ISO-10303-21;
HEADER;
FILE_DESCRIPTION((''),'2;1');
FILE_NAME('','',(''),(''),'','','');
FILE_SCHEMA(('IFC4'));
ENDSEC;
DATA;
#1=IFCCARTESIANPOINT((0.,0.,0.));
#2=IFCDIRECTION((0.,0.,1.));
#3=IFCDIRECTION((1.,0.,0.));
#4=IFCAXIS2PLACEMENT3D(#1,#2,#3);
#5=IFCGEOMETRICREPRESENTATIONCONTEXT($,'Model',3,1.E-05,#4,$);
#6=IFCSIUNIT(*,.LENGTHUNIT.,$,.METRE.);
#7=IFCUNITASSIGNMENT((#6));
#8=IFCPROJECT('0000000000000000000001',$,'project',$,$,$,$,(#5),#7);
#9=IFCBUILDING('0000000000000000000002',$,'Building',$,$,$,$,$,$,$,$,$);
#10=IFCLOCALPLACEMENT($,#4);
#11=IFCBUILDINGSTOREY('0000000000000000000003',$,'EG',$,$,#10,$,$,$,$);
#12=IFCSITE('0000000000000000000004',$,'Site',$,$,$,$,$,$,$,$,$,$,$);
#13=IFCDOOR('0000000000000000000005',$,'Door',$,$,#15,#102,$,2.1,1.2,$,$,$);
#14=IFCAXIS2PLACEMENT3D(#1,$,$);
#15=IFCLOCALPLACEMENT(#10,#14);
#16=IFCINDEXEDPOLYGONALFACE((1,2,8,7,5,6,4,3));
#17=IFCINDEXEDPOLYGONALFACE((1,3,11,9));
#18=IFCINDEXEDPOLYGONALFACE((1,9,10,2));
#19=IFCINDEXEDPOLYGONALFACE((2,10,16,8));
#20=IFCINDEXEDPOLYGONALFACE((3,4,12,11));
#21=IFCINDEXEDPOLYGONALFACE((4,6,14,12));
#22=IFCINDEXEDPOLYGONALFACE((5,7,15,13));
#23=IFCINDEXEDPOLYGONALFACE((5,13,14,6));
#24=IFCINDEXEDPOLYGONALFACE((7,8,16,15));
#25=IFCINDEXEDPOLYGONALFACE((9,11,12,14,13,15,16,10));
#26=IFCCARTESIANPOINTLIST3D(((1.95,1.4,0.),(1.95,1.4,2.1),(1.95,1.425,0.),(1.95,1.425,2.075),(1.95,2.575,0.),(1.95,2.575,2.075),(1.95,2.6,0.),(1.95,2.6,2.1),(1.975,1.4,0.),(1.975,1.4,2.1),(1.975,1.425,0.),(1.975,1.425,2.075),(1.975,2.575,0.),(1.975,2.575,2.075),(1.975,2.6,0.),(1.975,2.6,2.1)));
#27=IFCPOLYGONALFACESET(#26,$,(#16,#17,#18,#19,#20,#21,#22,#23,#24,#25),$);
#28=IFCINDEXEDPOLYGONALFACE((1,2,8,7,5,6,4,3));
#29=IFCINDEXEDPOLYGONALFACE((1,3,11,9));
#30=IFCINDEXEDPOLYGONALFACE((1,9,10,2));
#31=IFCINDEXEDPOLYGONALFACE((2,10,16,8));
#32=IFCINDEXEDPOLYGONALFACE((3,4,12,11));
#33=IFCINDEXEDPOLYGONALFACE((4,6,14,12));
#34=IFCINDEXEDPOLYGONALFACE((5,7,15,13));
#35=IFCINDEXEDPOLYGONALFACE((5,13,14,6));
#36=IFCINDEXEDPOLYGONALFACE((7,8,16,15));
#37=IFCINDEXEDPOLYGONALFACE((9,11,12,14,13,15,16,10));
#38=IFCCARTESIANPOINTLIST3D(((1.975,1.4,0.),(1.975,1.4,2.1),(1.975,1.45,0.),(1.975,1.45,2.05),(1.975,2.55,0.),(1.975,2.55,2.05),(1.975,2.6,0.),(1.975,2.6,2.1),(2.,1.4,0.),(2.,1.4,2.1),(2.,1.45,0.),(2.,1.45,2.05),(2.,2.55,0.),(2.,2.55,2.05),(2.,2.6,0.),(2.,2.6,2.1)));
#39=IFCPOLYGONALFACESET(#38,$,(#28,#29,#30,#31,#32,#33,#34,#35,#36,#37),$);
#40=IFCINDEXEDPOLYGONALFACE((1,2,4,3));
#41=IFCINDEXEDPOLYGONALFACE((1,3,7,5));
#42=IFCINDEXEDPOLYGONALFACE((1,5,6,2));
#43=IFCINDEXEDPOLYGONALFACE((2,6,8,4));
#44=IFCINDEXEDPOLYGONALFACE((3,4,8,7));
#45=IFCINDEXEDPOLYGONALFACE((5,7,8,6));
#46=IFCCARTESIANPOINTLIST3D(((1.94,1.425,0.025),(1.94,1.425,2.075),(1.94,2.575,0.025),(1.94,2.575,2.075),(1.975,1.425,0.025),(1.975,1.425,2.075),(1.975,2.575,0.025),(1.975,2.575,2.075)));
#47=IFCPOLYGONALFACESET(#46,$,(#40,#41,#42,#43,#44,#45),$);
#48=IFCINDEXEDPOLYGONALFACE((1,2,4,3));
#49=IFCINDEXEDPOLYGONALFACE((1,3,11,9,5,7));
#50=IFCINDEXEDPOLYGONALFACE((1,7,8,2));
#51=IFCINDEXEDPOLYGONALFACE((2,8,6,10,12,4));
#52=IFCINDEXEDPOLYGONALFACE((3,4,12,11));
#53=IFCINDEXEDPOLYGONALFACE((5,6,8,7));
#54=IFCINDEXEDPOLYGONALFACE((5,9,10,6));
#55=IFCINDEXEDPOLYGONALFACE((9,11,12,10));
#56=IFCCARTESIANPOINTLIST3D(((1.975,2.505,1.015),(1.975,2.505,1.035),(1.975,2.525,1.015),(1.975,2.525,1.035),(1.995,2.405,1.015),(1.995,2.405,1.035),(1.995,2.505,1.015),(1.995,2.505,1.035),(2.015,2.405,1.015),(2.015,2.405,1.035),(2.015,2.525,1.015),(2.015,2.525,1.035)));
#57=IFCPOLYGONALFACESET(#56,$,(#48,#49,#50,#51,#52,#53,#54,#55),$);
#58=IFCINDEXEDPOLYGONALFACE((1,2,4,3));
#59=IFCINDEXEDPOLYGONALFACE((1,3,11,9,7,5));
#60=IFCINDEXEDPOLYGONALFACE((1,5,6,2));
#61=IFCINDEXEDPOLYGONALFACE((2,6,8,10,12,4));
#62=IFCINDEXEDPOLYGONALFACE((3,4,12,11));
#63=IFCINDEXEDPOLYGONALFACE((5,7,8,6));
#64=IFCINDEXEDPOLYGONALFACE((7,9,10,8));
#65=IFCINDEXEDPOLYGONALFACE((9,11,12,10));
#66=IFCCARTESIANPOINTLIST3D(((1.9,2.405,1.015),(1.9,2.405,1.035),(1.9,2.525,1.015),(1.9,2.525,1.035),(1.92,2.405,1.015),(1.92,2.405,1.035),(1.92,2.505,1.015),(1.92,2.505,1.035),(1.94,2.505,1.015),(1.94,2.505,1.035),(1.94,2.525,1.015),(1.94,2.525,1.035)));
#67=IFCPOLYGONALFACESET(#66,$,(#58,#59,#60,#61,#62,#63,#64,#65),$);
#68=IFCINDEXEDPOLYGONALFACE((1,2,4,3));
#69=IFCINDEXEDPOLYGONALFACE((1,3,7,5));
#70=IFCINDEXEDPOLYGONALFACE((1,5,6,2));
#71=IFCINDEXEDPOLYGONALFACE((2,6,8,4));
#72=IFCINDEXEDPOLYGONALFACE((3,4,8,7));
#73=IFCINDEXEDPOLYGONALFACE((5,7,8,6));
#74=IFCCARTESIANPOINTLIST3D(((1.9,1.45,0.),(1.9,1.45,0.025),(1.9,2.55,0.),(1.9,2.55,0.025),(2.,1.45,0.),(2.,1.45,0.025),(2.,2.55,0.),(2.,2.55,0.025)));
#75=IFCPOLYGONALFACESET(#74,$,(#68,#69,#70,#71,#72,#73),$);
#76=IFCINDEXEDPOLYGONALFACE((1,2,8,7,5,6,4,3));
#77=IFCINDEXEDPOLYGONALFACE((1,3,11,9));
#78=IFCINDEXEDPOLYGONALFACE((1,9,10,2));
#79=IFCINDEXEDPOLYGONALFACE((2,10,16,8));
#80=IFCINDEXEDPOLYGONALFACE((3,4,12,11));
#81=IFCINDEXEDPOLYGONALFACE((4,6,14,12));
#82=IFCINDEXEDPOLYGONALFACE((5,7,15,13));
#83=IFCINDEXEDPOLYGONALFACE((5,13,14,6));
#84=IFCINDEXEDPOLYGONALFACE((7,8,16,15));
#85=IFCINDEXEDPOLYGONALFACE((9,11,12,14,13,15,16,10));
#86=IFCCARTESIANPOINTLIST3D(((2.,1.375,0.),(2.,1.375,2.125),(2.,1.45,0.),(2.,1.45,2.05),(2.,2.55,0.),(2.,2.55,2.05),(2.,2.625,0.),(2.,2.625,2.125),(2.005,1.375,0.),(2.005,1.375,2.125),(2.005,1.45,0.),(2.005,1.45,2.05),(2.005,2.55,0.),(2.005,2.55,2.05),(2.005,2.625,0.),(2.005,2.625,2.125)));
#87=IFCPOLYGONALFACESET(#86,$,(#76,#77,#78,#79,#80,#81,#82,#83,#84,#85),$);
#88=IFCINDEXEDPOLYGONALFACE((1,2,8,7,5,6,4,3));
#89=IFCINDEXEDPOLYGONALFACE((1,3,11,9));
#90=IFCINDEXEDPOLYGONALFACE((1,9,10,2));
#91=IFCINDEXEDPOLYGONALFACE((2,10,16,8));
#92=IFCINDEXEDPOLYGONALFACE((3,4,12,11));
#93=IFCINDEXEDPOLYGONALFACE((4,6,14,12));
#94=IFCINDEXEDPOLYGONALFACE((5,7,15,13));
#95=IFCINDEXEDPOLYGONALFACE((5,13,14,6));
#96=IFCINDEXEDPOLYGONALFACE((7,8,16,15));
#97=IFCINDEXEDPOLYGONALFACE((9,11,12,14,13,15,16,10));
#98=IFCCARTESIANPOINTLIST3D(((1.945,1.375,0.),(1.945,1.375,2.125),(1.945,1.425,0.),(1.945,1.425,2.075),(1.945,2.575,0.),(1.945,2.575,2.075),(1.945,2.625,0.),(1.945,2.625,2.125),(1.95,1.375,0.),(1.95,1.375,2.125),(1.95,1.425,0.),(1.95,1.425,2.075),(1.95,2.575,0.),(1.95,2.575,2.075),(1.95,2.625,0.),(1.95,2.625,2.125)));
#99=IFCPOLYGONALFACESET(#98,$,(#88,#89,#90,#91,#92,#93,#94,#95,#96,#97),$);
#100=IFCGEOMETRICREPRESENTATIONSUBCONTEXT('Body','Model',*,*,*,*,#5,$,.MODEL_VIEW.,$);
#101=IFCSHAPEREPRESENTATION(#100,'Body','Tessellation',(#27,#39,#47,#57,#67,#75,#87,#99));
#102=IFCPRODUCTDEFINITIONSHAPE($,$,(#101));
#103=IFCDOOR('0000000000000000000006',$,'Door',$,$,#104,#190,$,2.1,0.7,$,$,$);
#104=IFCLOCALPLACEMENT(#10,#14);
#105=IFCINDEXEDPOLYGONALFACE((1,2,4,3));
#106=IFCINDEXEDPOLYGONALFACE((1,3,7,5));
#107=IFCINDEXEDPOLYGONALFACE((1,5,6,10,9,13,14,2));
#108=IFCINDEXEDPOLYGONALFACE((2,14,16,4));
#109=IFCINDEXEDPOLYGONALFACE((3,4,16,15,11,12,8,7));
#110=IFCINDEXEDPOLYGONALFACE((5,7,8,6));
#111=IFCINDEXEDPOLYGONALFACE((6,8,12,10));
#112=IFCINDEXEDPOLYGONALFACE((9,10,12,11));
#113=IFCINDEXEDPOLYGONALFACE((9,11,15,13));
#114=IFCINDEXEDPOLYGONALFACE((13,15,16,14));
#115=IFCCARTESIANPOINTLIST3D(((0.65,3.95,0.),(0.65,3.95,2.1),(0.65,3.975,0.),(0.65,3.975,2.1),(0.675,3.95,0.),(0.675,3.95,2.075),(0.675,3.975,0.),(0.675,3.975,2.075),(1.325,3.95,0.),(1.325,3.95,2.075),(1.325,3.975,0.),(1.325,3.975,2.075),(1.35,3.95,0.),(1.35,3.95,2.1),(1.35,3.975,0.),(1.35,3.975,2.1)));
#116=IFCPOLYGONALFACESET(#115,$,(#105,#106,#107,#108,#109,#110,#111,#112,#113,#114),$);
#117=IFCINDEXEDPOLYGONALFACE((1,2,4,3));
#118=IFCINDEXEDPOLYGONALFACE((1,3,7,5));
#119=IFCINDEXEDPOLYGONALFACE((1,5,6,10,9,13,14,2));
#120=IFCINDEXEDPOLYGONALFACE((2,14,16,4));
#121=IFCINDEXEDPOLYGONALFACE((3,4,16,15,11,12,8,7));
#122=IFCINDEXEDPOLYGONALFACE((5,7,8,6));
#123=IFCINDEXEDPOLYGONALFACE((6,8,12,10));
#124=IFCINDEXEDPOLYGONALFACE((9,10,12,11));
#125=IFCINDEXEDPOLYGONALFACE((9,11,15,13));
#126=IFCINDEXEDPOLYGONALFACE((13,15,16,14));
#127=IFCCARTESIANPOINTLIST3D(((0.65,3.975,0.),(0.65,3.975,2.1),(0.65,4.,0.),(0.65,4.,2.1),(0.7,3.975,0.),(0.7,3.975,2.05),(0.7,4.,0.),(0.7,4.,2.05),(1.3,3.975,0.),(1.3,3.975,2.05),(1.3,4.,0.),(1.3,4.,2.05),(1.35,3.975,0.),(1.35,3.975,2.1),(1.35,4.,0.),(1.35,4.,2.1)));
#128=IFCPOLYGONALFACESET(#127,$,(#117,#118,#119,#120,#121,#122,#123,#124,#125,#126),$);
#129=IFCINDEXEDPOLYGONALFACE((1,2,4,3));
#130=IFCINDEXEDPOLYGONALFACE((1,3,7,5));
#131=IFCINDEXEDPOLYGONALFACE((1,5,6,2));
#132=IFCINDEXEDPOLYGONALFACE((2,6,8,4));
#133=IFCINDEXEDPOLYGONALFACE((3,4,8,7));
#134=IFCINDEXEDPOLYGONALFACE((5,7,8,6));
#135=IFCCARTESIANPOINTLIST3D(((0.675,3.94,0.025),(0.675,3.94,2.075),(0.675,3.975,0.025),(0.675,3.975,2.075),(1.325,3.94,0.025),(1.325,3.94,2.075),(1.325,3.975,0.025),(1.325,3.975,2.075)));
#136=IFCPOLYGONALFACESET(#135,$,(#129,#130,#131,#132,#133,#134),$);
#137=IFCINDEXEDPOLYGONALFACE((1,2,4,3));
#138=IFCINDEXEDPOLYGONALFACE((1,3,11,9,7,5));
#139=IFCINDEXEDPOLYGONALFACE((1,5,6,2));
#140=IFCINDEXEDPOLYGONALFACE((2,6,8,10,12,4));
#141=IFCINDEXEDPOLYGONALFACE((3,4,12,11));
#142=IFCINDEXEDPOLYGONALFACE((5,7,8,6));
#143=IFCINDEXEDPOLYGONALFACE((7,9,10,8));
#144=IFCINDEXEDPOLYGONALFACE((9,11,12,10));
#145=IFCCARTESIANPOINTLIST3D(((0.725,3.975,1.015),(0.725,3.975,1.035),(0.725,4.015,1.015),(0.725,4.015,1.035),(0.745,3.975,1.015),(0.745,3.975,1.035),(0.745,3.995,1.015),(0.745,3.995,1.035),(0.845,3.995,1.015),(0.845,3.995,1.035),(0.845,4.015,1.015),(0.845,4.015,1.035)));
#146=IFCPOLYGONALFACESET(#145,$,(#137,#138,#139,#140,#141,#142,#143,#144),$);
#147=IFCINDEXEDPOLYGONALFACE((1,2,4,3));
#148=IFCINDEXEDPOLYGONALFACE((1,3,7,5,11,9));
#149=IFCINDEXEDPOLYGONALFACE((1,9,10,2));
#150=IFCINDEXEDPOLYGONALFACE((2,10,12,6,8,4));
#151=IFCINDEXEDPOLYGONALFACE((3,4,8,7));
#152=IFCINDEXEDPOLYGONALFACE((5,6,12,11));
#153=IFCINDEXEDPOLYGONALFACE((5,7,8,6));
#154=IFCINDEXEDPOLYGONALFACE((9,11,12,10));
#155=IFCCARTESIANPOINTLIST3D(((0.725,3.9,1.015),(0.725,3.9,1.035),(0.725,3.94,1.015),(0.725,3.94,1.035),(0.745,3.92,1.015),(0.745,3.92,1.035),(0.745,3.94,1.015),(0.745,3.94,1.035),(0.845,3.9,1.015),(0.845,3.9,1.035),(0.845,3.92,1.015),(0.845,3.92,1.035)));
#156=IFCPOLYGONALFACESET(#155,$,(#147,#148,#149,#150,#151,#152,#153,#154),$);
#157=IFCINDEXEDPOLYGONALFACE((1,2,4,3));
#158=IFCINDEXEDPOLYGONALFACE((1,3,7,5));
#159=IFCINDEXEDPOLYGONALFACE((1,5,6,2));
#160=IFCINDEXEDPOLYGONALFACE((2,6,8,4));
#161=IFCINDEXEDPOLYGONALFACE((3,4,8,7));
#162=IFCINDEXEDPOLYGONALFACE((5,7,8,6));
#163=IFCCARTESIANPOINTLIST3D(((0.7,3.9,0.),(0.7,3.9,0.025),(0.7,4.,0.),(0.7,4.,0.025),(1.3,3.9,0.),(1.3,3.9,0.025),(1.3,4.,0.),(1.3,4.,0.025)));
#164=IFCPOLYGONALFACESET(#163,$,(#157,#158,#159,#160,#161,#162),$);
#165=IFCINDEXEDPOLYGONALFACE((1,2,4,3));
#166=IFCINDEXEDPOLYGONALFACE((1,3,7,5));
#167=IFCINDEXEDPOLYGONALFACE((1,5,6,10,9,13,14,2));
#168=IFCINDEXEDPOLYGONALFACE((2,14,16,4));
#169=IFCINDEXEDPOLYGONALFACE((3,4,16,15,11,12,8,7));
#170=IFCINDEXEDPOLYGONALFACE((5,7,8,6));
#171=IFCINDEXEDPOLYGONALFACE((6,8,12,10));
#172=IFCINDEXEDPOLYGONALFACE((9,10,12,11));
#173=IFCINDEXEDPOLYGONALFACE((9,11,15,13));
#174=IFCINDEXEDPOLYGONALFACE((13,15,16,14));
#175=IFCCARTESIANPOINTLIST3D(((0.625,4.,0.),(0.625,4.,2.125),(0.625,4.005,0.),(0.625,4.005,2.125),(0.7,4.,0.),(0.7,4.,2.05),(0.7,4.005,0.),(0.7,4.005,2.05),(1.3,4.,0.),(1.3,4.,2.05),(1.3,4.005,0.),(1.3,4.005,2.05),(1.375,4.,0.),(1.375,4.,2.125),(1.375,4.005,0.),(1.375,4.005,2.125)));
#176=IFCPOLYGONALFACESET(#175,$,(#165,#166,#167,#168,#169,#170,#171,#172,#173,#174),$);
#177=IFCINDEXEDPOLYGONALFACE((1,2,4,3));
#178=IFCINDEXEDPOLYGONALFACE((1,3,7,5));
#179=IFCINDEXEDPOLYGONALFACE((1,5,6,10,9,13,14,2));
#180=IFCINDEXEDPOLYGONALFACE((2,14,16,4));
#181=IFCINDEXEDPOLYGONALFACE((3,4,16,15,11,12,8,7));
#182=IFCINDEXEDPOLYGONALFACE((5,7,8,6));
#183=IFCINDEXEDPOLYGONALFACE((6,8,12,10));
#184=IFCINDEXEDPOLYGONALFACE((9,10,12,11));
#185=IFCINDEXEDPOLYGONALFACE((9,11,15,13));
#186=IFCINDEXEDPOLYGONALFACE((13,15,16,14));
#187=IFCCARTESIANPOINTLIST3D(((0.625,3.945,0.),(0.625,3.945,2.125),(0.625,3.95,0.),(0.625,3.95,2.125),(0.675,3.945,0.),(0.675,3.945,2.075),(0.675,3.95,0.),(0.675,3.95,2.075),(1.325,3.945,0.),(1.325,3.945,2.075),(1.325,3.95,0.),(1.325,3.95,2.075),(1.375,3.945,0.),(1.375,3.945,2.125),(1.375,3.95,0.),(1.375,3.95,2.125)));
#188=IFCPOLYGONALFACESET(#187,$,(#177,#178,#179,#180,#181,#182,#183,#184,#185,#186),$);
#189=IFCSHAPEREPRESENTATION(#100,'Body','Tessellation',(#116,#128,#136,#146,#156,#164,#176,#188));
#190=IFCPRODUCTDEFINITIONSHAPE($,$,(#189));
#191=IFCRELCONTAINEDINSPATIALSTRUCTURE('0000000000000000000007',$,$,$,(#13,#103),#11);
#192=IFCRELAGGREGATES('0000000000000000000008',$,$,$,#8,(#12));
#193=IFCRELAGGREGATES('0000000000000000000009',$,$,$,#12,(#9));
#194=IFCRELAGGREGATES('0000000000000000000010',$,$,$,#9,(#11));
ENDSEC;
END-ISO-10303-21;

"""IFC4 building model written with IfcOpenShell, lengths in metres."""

from ifc_helpers import new_model, si_unit, frame, origin_with_axes, place, context, subcontext, project, spatial, line, indexed_curve, outline, extrude, element, save


model = new_model("IFC4")

# Units and contexts
model_context = context("Model", 3, precision=1e-05, world=origin_with_axes())
body_context = subcontext(model_context, "Body", "Model", "MODEL_VIEW")
ifc_project = project(units=[si_unit("LENGTHUNIT", "METRE")], contexts=[model_context])

# Site, building, storey
site = spatial("IfcSite", under=ifc_project, Name="Site")
building = spatial("IfcBuilding", under=site, Name="Building")
storey_placement = place(None, origin_with_axes())
storey = spatial("IfcBuildingStorey", under=building, at=storey_placement, Name="EG")

# Doors
door_1_placement = place(storey_placement, frame((2.0, 1.4, 0.0), z_axis=(0.0, 0.0, 1.0), x_axis=(0.0, 1.0, 0.0)))
element("IfcDoor", 1, at=door_1_placement, inside=storey, Name="Door", OverallHeight=2.1, OverallWidth=1.2, context=body_context, shape_type="SweptSolid", body=[
    extrude(outline(indexed_curve([(0.0, 0.0), (0.0, 2.1), (1.2, 2.1), (1.2, 0.0), (1.175, 0.0), (1.175, 2.075), (0.025, 2.075), (0.025, 0.0)], segments=[line(1, 2, 3, 4, 5, 6, 7, 8, 1)])), frame((0.0, 0.025, 0.0), z_axis=(0.0, -1.0, 0.0), x_axis=(1.0, 0.0, 0.0)), (0.0, 0.0, -1.0), 0.025),
    extrude(outline(indexed_curve([(0.0, 0.0), (0.0, 2.1), (1.2, 2.1), (1.2, 0.0), (1.15, 0.0), (1.15, 2.05), (0.05, 2.05), (0.05, 0.0)], segments=[line(1, 2, 3, 4, 5, 6, 7, 8, 1)])), frame((0.0, 0.0, 0.0), z_axis=(0.0, -1.0, 0.0), x_axis=(1.0, 0.0, 0.0)), (0.0, 0.0, -1.0), 0.025),
    extrude(outline(indexed_curve([(0.0, 0.0), (1.15, 0.0), (1.15, 0.035), (0.0, 0.035)], segments=[line(1, 2, 3, 4, 1)])), frame((0.025, 0.025, 0.025), z_axis=(0.0, 0.0, 1.0), x_axis=(1.0, 0.0, 0.0)), (0.0, 0.0, 1.0), 2.05),
    extrude(outline(indexed_curve([(0.0, 0.0), (0.0, -0.04), (-0.12, -0.04), (-0.12, -0.02), (-0.02, -0.02), (-0.02, 0.0)], segments=[line(1, 2, 3, 4, 5, 6, 1)])), frame((1.125, 0.025, 1.015), z_axis=(0.0, 0.0, 1.0), x_axis=(1.0, 0.0, 0.0)), (0.0, 0.0, 1.0), 0.02),
    extrude(outline(indexed_curve([(0.0, 0.0), (0.0, 0.04), (-0.12, 0.04), (-0.12, 0.02), (-0.02, 0.02), (-0.02, 0.0)], segments=[line(1, 2, 3, 4, 5, 6, 1)])), frame((1.125, 0.06, 1.015), z_axis=(0.0, 0.0, 1.0), x_axis=(1.0, 0.0, 0.0)), (0.0, 0.0, 1.0), 0.02),
    extrude(outline(indexed_curve([(0.0, 0.0), (1.1, 0.0), (1.1, 0.1), (0.0, 0.1)], segments=[line(1, 2, 3, 4, 1)])), frame((0.05, 0.0, 0.0), z_axis=(0.0, 0.0, 1.0), x_axis=(1.0, 0.0, 0.0)), (0.0, 0.0, 1.0), 0.025),
    extrude(outline(indexed_curve([(0.0, 0.0), (0.0, 2.125), (1.25, 2.125), (1.25, 0.0), (1.175, 0.0), (1.175, 2.05), (0.075, 2.05), (0.075, 0.0)], segments=[line(1, 2, 3, 4, 5, 6, 7, 8, 1)])), frame((-0.025, -0.005, 0.0), z_axis=(0.0, -1.0, 0.0), x_axis=(1.0, 0.0, 0.0)), (0.0, 0.0, -1.0), 0.005),
    extrude(outline(indexed_curve([(0.0, 0.0), (0.0, 2.125), (1.25, 2.125), (1.25, 0.0), (1.2, 0.0), (1.2, 2.075), (0.05, 2.075), (0.05, 0.0)], segments=[line(1, 2, 3, 4, 5, 6, 7, 8, 1)])), frame((-0.025, 0.05, 0.0), z_axis=(0.0, -1.0, 0.0), x_axis=(1.0, 0.0, 0.0)), (0.0, 0.0, -1.0), 0.005),
])
door_2_placement = place(storey_placement, frame((1.35, 4.0, 0.0), z_axis=(0.0, 0.0, 1.0), x_axis=(-1.0, 0.0, 0.0)))
element("IfcDoor", 2, at=door_2_placement, inside=storey, Name="Door", OverallHeight=2.1, OverallWidth=0.7, context=body_context, shape_type="SweptSolid", body=[
    extrude(outline(indexed_curve([(0.0, 0.0), (0.0, 2.1), (0.7, 2.1), (0.7, 0.0), (0.675, 0.0), (0.675, 2.075), (0.025, 2.075), (0.025, 0.0)], segments=[line(1, 2, 3, 4, 5, 6, 7, 8, 1)])), frame((0.0, 0.025, 0.0), z_axis=(0.0, -1.0, 0.0), x_axis=(1.0, 0.0, 0.0)), (0.0, 0.0, -1.0), 0.025),
    extrude(outline(indexed_curve([(0.0, 0.0), (0.0, 2.1), (0.7, 2.1), (0.7, 0.0), (0.65, 0.0), (0.65, 2.05), (0.05, 2.05), (0.05, 0.0)], segments=[line(1, 2, 3, 4, 5, 6, 7, 8, 1)])), frame((0.0, 0.0, 0.0), z_axis=(0.0, -1.0, 0.0), x_axis=(1.0, 0.0, 0.0)), (0.0, 0.0, -1.0), 0.025),
    extrude(outline(indexed_curve([(0.0, 0.0), (0.65, 0.0), (0.65, 0.035), (0.0, 0.035)], segments=[line(1, 2, 3, 4, 1)])), frame((0.025, 0.025, 0.025), z_axis=(0.0, 0.0, 1.0), x_axis=(1.0, 0.0, 0.0)), (0.0, 0.0, 1.0), 2.05),
    extrude(outline(indexed_curve([(0.0, 0.0), (0.0, -0.04), (-0.12, -0.04), (-0.12, -0.02), (-0.02, -0.02), (-0.02, 0.0)], segments=[line(1, 2, 3, 4, 5, 6, 1)])), frame((0.625, 0.025, 1.015), z_axis=(0.0, 0.0, 1.0), x_axis=(1.0, 0.0, 0.0)), (0.0, 0.0, 1.0), 0.02),
    extrude(outline(indexed_curve([(0.0, 0.0), (0.0, 0.04), (-0.12, 0.04), (-0.12, 0.02), (-0.02, 0.02), (-0.02, 0.0)], segments=[line(1, 2, 3, 4, 5, 6, 1)])), frame((0.625, 0.06, 1.015), z_axis=(0.0, 0.0, 1.0), x_axis=(1.0, 0.0, 0.0)), (0.0, 0.0, 1.0), 0.02),
    extrude(outline(indexed_curve([(0.0, 0.0), (0.6, 0.0), (0.6, 0.1), (0.0, 0.1)], segments=[line(1, 2, 3, 4, 1)])), frame((0.05, 0.0, 0.0), z_axis=(0.0, 0.0, 1.0), x_axis=(1.0, 0.0, 0.0)), (0.0, 0.0, 1.0), 0.025),
    extrude(outline(indexed_curve([(0.0, 0.0), (0.0, 2.125), (0.75, 2.125), (0.75, 0.0), (0.675, 0.0), (0.675, 2.05), (0.075, 2.05), (0.075, 0.0)], segments=[line(1, 2, 3, 4, 5, 6, 7, 8, 1)])), frame((-0.025, -0.005, 0.0), z_axis=(0.0, -1.0, 0.0), x_axis=(1.0, 0.0, 0.0)), (0.0, 0.0, -1.0), 0.005),
    extrude(outline(indexed_curve([(0.0, 0.0), (0.0, 2.125), (0.75, 2.125), (0.75, 0.0), (0.7, 0.0), (0.7, 2.075), (0.05, 2.075), (0.05, 0.0)], segments=[line(1, 2, 3, 4, 5, 6, 7, 8, 1)])), frame((-0.025, 0.05, 0.0), z_axis=(0.0, -1.0, 0.0), x_axis=(1.0, 0.0, 0.0)), (0.0, 0.0, -1.0), 0.005),
])

save(model, "model.ifc")
